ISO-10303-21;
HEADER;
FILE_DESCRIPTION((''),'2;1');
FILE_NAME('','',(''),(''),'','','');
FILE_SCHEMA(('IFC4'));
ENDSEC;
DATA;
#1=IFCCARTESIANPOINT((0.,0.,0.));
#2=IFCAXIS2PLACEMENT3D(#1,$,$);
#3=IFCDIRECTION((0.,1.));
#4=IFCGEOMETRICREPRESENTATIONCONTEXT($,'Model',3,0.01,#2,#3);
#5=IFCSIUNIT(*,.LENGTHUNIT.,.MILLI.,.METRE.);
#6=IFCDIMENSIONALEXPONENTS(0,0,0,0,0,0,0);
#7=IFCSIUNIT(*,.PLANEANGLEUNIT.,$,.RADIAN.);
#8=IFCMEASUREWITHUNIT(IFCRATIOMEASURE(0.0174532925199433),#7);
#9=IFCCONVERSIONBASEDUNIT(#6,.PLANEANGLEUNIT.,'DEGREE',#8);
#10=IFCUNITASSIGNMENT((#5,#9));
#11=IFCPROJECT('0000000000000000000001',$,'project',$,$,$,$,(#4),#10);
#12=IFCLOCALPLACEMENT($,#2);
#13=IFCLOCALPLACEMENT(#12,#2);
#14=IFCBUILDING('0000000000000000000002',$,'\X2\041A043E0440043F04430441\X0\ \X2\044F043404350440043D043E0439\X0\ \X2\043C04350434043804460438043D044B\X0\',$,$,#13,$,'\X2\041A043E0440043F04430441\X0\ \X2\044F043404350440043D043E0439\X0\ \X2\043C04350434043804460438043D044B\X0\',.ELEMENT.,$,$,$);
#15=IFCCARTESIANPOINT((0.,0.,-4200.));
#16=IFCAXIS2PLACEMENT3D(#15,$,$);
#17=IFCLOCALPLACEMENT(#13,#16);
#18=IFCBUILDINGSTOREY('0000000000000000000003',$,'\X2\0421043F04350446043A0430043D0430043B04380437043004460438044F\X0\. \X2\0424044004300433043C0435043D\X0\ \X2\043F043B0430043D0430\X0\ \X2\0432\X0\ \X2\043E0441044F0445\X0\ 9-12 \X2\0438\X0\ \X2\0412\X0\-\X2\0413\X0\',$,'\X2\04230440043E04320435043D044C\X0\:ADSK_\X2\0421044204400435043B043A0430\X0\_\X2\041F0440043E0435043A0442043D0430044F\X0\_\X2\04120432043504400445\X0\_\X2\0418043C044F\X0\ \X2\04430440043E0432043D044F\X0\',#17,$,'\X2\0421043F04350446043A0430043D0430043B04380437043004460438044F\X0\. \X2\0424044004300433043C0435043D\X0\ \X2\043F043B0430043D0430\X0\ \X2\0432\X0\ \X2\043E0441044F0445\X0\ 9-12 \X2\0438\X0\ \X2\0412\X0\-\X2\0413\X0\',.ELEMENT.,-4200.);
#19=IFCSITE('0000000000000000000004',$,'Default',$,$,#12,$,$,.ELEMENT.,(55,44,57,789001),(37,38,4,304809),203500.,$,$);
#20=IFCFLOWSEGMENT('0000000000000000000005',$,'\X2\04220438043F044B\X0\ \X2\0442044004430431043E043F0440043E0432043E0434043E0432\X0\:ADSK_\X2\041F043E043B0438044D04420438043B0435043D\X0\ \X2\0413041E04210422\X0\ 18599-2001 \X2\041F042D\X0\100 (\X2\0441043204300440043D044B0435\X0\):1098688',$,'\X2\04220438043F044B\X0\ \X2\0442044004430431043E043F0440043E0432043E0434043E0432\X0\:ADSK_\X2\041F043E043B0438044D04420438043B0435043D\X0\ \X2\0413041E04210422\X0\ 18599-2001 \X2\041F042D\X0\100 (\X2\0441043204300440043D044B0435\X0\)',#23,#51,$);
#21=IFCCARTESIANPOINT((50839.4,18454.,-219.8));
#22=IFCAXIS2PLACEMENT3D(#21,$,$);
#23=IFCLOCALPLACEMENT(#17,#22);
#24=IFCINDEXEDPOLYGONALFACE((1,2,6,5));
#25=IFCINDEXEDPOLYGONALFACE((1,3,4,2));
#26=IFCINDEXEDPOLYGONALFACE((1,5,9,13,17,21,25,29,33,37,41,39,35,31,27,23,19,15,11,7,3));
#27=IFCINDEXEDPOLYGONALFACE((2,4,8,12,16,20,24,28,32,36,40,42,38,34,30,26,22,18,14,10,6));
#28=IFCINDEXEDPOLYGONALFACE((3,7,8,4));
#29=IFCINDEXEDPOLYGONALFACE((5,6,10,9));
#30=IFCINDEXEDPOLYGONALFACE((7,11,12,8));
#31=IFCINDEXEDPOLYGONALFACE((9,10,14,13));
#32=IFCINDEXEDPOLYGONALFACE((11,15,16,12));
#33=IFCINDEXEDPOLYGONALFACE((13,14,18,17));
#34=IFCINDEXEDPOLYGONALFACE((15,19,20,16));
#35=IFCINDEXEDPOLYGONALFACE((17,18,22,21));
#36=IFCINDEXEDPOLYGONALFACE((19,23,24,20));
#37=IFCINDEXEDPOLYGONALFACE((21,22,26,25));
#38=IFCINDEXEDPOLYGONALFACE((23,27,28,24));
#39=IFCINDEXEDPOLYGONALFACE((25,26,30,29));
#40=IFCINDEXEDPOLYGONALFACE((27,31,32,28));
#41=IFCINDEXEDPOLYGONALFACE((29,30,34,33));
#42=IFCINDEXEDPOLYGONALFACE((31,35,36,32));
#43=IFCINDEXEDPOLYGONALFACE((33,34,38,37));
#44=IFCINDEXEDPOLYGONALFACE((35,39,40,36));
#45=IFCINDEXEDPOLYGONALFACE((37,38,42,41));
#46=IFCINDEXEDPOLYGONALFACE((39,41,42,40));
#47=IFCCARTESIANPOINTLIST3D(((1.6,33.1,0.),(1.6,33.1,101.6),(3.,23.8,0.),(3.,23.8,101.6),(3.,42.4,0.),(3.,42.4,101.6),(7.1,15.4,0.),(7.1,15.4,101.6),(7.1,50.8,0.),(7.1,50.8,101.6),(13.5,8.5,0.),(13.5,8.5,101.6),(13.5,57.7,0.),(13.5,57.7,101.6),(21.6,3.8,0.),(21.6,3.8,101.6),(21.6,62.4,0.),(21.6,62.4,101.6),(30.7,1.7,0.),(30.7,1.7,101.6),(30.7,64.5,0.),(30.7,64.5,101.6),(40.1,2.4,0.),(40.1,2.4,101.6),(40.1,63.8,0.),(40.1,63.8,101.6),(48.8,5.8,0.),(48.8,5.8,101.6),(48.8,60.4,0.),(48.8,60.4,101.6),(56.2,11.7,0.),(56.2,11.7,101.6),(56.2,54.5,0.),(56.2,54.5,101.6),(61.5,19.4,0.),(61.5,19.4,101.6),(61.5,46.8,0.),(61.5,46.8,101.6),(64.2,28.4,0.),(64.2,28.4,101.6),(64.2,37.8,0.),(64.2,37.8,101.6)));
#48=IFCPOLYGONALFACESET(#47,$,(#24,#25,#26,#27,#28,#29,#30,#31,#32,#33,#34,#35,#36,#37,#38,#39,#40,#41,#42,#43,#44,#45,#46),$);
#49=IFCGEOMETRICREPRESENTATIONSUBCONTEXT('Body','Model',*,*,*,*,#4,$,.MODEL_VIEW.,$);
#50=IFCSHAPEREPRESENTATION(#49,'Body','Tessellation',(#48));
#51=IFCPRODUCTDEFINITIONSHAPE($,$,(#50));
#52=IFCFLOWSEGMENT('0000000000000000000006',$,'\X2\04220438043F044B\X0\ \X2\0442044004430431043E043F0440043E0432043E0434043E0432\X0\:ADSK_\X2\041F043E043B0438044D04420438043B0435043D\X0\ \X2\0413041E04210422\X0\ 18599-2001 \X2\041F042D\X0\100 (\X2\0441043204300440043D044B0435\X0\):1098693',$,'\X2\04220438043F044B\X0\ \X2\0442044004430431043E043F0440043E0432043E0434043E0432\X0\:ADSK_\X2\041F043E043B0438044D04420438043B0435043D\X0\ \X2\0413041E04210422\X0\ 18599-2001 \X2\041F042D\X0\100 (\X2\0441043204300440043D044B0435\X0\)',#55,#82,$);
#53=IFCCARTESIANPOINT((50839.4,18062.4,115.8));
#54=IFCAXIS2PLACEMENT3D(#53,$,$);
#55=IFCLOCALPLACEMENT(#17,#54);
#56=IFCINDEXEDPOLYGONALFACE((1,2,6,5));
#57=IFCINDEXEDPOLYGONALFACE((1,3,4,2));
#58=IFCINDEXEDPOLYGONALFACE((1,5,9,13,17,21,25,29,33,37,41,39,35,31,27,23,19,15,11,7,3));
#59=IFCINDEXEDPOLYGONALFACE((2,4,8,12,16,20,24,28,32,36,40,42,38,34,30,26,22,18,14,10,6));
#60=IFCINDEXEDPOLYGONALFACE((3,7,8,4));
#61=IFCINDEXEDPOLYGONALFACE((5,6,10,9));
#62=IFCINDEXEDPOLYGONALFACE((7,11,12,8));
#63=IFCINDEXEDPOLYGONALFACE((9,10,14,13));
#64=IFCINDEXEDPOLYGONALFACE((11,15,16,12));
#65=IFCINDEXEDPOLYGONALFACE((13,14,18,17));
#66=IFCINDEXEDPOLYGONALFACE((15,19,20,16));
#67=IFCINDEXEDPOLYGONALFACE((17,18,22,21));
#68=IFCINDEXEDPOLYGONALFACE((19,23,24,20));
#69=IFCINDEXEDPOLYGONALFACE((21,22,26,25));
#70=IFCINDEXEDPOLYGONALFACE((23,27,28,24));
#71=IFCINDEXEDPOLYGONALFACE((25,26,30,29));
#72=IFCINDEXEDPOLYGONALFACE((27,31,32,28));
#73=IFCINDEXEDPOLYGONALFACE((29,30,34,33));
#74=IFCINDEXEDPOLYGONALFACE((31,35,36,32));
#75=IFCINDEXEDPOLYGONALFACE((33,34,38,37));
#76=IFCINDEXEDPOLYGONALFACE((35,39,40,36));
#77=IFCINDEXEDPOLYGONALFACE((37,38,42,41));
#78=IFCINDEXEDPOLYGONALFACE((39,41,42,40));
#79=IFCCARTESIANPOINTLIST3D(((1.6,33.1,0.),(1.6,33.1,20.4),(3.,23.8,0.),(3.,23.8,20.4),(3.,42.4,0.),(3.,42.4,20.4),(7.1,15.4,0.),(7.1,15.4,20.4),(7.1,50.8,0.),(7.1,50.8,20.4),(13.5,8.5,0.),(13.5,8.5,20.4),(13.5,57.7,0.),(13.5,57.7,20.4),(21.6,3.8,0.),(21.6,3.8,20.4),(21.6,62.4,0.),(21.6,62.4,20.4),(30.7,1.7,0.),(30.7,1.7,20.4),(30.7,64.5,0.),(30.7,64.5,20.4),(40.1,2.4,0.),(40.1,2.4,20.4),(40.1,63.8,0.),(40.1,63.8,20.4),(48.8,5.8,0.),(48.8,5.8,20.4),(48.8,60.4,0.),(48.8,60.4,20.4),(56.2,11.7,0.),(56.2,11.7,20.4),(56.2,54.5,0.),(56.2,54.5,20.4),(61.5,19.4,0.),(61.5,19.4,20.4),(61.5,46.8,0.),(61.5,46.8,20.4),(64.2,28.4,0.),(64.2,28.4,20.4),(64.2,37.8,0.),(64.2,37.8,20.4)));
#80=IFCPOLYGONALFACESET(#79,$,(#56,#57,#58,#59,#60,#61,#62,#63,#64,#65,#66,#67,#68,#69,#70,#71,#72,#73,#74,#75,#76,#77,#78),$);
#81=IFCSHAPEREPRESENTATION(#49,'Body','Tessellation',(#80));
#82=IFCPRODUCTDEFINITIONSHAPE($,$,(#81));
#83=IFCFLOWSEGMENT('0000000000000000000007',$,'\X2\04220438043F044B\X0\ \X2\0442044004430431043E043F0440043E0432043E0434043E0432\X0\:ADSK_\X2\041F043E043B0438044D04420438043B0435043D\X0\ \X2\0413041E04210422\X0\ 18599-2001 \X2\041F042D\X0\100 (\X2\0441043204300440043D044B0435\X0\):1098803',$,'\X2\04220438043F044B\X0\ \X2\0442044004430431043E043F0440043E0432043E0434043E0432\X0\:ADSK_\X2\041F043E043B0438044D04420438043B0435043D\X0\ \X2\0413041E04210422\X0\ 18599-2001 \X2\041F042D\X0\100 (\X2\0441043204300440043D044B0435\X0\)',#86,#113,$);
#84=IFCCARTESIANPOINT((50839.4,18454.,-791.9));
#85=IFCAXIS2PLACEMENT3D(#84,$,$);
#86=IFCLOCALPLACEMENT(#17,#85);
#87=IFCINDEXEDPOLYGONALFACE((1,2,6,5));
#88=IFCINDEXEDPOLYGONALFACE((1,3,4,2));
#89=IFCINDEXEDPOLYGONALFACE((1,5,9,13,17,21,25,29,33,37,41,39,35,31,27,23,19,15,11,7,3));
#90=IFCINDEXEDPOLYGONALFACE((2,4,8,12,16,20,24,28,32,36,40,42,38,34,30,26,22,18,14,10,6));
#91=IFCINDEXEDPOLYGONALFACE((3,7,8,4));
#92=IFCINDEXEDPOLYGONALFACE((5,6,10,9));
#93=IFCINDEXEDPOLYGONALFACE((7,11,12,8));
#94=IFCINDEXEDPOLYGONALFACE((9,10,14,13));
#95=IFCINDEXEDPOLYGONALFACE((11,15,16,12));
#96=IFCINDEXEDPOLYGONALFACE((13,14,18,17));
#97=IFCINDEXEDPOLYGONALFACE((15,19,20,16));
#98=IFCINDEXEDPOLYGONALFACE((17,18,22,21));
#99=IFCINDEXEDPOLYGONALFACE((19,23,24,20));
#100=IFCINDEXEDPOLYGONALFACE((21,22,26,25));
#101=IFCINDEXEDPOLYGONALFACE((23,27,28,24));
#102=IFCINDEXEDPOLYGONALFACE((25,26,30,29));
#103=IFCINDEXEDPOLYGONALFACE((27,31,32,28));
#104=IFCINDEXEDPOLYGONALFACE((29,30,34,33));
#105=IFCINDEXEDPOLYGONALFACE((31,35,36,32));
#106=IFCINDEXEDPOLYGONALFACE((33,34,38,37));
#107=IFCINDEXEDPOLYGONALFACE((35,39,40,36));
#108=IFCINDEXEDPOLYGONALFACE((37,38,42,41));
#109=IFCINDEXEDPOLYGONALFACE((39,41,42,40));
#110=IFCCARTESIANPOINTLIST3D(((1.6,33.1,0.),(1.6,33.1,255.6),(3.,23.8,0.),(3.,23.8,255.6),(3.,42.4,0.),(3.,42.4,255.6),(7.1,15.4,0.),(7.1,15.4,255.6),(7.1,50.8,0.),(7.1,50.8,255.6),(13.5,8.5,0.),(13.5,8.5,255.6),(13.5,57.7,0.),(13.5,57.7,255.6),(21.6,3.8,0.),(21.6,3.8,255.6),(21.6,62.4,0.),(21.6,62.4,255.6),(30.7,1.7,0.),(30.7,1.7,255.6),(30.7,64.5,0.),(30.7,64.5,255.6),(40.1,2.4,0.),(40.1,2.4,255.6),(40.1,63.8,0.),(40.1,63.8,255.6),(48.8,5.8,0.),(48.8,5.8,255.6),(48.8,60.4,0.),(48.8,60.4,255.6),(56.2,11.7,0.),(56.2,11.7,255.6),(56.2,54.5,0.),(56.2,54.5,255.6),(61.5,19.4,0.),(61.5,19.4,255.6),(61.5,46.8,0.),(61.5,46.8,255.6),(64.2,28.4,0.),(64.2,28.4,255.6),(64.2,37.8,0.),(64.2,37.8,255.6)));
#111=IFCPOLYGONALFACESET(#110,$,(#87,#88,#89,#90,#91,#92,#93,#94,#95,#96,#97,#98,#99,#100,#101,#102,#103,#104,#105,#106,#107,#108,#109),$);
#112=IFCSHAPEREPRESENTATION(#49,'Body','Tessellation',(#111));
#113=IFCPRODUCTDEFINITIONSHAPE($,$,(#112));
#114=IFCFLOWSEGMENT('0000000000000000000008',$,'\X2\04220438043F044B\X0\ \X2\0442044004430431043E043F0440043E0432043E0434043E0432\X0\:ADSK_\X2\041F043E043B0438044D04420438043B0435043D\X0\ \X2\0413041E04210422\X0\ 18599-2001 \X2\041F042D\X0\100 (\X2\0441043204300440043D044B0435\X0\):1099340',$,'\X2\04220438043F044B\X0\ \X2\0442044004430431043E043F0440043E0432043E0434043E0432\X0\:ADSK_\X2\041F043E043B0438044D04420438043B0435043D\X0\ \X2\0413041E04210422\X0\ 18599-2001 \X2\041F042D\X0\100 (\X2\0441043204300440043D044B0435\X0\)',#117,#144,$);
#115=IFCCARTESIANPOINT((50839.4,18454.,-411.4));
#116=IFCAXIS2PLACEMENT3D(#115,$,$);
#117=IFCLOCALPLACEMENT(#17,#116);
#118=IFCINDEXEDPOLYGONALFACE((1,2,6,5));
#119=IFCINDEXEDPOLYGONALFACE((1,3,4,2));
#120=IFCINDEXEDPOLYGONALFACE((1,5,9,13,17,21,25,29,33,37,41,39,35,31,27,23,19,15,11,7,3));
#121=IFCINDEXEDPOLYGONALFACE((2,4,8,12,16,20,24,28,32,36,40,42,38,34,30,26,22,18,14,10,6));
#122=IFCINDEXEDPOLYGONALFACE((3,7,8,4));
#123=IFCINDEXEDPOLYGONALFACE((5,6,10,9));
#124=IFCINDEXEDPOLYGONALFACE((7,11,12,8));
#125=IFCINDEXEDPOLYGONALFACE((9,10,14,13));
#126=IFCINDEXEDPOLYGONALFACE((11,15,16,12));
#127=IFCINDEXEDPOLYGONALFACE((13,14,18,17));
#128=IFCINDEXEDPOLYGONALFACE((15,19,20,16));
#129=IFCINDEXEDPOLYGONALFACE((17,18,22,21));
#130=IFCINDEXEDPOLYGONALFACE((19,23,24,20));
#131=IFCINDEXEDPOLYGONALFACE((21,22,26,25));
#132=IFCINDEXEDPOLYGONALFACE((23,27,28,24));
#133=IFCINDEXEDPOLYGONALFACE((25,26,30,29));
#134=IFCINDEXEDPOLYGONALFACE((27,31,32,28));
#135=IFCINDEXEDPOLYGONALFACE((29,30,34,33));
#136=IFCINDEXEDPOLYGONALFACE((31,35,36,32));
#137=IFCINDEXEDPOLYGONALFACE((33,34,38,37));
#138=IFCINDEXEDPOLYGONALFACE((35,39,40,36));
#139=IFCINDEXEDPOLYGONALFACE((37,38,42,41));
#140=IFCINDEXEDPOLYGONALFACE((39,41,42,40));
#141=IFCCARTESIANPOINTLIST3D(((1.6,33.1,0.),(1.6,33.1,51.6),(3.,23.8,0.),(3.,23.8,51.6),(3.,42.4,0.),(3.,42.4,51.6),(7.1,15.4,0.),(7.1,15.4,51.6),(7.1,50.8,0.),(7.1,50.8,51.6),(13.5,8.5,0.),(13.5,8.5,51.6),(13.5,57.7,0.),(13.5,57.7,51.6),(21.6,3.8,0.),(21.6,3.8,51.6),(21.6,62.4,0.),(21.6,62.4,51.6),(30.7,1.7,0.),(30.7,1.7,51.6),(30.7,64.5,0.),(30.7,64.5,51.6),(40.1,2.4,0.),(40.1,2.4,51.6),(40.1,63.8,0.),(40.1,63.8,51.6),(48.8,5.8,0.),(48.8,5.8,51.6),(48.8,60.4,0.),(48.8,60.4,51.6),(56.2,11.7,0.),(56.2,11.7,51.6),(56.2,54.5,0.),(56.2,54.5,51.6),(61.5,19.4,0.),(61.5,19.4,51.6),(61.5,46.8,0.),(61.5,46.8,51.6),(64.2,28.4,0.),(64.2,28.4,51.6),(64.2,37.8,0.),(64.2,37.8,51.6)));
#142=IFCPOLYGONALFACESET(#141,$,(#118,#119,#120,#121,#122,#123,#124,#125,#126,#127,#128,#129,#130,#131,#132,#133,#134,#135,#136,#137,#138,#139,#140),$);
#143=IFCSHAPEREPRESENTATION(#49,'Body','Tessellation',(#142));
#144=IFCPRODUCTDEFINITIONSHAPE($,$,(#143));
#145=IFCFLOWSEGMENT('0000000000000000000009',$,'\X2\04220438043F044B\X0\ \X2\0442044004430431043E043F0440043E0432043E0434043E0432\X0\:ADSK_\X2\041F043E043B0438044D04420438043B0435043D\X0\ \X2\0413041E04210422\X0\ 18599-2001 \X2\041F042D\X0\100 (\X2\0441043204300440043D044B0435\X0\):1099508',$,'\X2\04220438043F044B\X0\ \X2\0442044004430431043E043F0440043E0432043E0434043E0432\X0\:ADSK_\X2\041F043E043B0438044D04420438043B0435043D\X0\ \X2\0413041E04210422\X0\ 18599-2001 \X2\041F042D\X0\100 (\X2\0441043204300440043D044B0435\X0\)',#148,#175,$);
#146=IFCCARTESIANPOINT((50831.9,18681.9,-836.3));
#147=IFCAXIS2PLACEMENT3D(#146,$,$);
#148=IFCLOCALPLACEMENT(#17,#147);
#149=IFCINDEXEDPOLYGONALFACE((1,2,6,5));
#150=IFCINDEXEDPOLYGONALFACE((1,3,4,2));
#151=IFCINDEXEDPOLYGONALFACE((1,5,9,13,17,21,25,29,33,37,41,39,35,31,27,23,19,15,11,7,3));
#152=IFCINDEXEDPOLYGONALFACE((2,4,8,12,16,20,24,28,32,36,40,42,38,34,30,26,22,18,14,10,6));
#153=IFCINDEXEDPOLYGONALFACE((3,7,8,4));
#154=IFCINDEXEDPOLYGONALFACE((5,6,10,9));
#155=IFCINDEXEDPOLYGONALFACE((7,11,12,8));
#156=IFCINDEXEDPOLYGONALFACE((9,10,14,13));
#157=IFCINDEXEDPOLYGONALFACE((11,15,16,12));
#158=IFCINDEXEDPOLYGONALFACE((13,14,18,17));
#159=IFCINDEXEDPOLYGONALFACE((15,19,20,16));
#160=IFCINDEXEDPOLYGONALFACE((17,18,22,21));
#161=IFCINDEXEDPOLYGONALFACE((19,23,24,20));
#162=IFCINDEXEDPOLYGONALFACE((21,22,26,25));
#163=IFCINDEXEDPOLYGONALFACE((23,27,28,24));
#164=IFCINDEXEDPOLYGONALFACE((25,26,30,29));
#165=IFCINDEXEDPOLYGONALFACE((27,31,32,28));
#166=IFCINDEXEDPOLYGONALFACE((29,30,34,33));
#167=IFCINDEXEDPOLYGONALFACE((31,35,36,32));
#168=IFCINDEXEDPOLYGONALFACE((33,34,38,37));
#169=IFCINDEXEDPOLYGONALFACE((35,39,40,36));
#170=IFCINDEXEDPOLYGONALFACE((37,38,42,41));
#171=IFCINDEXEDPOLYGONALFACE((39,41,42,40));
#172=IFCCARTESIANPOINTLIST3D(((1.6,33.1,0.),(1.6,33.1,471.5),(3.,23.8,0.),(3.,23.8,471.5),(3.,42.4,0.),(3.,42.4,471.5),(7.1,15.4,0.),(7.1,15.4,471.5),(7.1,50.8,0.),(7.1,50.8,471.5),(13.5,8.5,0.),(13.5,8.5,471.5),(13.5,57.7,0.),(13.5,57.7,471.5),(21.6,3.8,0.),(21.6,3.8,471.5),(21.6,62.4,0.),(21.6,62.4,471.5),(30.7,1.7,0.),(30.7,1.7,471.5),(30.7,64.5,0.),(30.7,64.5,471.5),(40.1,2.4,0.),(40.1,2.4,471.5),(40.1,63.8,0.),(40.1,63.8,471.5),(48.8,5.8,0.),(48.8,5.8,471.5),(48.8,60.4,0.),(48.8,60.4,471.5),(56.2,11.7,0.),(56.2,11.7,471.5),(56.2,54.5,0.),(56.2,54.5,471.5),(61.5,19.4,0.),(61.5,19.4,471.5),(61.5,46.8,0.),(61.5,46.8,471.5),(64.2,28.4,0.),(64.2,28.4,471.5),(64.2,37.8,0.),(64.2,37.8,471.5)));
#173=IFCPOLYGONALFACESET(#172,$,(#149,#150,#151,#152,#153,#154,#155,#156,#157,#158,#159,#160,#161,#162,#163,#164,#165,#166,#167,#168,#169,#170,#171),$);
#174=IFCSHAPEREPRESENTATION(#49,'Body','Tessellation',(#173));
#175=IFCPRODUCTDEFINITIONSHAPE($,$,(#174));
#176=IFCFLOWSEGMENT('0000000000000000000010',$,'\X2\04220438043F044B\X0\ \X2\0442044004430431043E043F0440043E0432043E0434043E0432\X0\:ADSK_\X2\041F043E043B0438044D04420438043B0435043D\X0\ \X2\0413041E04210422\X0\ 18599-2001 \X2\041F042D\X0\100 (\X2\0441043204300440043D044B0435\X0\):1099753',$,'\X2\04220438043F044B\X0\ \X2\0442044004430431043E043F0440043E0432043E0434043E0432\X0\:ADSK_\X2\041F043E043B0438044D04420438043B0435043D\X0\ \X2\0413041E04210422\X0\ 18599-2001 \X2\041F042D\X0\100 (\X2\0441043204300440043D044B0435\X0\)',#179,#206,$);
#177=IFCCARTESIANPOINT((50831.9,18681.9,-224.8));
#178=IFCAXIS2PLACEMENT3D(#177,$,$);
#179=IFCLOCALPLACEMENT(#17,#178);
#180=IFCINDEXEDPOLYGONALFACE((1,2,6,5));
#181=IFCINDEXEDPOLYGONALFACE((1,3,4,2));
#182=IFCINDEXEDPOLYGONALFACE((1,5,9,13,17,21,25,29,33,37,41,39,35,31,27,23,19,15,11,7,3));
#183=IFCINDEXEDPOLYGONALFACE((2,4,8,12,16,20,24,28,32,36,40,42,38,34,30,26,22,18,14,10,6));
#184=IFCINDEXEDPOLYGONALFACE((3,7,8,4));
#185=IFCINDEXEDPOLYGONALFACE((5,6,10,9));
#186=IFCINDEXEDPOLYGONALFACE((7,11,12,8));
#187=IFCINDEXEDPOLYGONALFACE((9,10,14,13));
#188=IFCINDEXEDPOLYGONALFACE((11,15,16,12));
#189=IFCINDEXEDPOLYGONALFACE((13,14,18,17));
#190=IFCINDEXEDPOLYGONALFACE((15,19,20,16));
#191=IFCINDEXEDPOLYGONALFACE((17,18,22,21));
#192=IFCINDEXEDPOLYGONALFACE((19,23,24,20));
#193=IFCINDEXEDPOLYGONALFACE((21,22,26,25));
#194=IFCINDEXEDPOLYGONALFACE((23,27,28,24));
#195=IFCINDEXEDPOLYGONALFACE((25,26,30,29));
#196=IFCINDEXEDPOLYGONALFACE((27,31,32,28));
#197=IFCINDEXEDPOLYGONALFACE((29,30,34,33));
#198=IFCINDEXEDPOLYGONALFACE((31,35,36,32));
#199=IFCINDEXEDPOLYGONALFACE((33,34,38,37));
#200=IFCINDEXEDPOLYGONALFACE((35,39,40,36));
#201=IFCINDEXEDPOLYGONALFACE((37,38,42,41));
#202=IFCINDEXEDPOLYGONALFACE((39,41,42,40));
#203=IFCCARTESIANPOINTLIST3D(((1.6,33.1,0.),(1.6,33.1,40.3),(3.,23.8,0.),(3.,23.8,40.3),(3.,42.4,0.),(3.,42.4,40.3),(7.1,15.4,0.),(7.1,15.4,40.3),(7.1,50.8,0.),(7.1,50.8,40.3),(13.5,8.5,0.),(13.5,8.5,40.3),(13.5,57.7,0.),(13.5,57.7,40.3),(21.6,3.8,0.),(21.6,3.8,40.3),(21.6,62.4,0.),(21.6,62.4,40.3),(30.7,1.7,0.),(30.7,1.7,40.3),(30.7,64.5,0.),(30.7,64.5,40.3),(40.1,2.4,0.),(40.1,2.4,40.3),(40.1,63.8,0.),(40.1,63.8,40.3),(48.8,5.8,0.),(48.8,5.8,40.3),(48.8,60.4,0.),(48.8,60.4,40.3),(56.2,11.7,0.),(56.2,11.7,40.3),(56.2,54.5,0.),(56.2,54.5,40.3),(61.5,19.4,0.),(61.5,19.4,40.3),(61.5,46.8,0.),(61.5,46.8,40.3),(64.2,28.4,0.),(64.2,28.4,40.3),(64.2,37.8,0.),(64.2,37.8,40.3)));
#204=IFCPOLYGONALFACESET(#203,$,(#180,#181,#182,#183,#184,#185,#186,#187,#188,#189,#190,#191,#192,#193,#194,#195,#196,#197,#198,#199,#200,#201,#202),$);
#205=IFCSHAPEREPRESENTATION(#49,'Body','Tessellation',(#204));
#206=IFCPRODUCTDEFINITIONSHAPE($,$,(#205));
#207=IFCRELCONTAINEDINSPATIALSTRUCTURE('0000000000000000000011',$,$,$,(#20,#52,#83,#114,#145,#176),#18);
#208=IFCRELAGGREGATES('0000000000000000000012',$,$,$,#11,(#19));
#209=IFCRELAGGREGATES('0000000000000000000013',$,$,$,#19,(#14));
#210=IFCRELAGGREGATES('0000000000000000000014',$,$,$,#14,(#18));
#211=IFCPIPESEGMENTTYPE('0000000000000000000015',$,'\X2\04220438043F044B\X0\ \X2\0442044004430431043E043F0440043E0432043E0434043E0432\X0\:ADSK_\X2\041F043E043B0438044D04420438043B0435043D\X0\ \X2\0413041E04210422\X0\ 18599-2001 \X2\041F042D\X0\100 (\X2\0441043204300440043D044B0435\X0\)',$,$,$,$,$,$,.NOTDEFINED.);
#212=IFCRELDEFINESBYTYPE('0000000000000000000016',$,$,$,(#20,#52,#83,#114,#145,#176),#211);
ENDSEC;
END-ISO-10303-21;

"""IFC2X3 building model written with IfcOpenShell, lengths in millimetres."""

from ifc_helpers import new_model, entity, si_unit, converted_unit, direction, frame, frame_2d, origin, origin_2d_with_axis, place, context, subcontext, project, spatial, circle, extrude, type_object, element, save


model = new_model("IFC2X3")

# Units and contexts
model_context = context("Model", 3, precision=0.01, world=origin(), true_north=direction((0.0, 1.0)))
body_context = subcontext(model_context, "Body", "Model", "MODEL_VIEW")
ifc_project = project(units=[si_unit("LENGTHUNIT", "METRE", prefix="MILLI"), converted_unit("PLANEANGLEUNIT", "DEGREE", entity("IfcRatioMeasure", 0.0174532925199433), si_unit("PLANEANGLEUNIT", "RADIAN"), dimensions=[0, 0, 0, 0, 0, 0, 0])], contexts=[model_context])

# Site, building, storey
site_placement = place(None, frame((0.0, 0.0, 0.0)))
site = spatial("IfcSite", under=ifc_project, at=site_placement, Name="Default", CompositionType="ELEMENT", RefLatitude=(55, 44, 57, 789001), RefLongitude=(37, 38, 4, 304809), RefElevation=203500.0)
building_placement = place(site_placement, origin())
building = spatial("IfcBuilding", under=site, at=building_placement, Name="Корпус ядерной медицины", LongName="Корпус ядерной медицины", CompositionType="ELEMENT")
storey_placement = place(building_placement, frame((0.0, 0.0, -4200.0)))
storey = spatial("IfcBuildingStorey", under=building, at=storey_placement, Name="Спецканализация. Фрагмен плана в осях 9-12 и В-Г", ObjectType="Уровень:ADSK_Стрелка_Проектная_Вверх_Имя уровня", LongName="Спецканализация. Фрагмен плана в осях 9-12 и В-Г", CompositionType="ELEMENT", Elevation=-4200.0)

# Flow segments
pipe_segment_type = type_object("IfcPipeSegmentType", Name="Типы трубопроводов:ADSK_Полиэтилен ГОСТ 18599-2001 ПЭ100 (сварные)", PredefinedType="NOTDEFINED")
flow_segment_1_placement = place(storey_placement, frame((50839.4, 18454.0, -219.8)))
element("IfcFlowSegment", 1, at=flow_segment_1_placement, inside=storey, type_object=pipe_segment_type, Name="Типы трубопроводов:ADSK_Полиэтилен ГОСТ 18599-2001 ПЭ100 (сварные):1098688", ObjectType="Типы трубопроводов:ADSK_Полиэтилен ГОСТ 18599-2001 ПЭ100 (сварные)", context=body_context, shape_type="SweptSolid", body=[
    extrude(circle(Radius=31.5, at=frame_2d((0.0, 0.0), x_axis=(1.0, 0.0))), frame((33.1, 33.1, 0.0), z_axis=(0.0, 0.0, 1.0), x_axis=(-1.0, 0.0, 0.0)), (0.0, 0.0, 1.0), 101.6),
])
flow_segment_2_placement = place(storey_placement, frame((50839.4, 18062.4, 115.8)))
element("IfcFlowSegment", 2, at=flow_segment_2_placement, inside=storey, type_object=pipe_segment_type, Name="Типы трубопроводов:ADSK_Полиэтилен ГОСТ 18599-2001 ПЭ100 (сварные):1098693", ObjectType="Типы трубопроводов:ADSK_Полиэтилен ГОСТ 18599-2001 ПЭ100 (сварные)", context=body_context, shape_type="SweptSolid", body=[
    extrude(circle(Radius=31.5, at=frame_2d((0.0, 0.0), x_axis=(1.0, 0.0))), frame((33.1, 33.1, 0.0), z_axis=(0.0, 0.0, 1.0), x_axis=(-1.0, 0.0, 0.0)), (0.0, 0.0, 1.0), 20.4),
])
flow_segment_3_placement = place(storey_placement, frame((50839.4, 18454.0, -791.9)))
element("IfcFlowSegment", 3, at=flow_segment_3_placement, inside=storey, type_object=pipe_segment_type, Name="Типы трубопроводов:ADSK_Полиэтилен ГОСТ 18599-2001 ПЭ100 (сварные):1098803", ObjectType="Типы трубопроводов:ADSK_Полиэтилен ГОСТ 18599-2001 ПЭ100 (сварные)", context=body_context, shape_type="SweptSolid", body=[
    extrude(circle(Radius=31.5, at=origin_2d_with_axis()), frame((33.1, 33.1, 0.0), z_axis=(0.0, 0.0, 1.0), x_axis=(-1.0, 0.0, 0.0)), (0.0, 0.0, 1.0), 255.6),
])
flow_segment_4_placement = place(storey_placement, frame((50839.4, 18454.0, -411.4)))
element("IfcFlowSegment", 4, at=flow_segment_4_placement, inside=storey, type_object=pipe_segment_type, Name="Типы трубопроводов:ADSK_Полиэтилен ГОСТ 18599-2001 ПЭ100 (сварные):1099340", ObjectType="Типы трубопроводов:ADSK_Полиэтилен ГОСТ 18599-2001 ПЭ100 (сварные)", context=body_context, shape_type="SweptSolid", body=[
    extrude(circle(Radius=31.5, at=frame_2d((0.0, 0.0), x_axis=(1.0, 0.0))), frame((33.1, 33.1, 0.0), z_axis=(0.0, 0.0, 1.0), x_axis=(-1.0, 0.0, 0.0)), (0.0, 0.0, 1.0), 51.6),
])
flow_segment_5_placement = place(storey_placement, frame((50831.9, 18681.9, -836.3)))
element("IfcFlowSegment", 5, at=flow_segment_5_placement, inside=storey, type_object=pipe_segment_type, Name="Типы трубопроводов:ADSK_Полиэтилен ГОСТ 18599-2001 ПЭ100 (сварные):1099508", ObjectType="Типы трубопроводов:ADSK_Полиэтилен ГОСТ 18599-2001 ПЭ100 (сварные)", context=body_context, shape_type="SweptSolid", body=[
    extrude(circle(Radius=31.5, at=frame_2d((0.0, 0.0), x_axis=(1.0, 0.0))), frame((33.1, 33.1, 0.0), z_axis=(0.0, 0.0, 1.0), x_axis=(-1.0, 0.0, 0.0)), (0.0, 0.0, 1.0), 471.5),
])
flow_segment_6_placement = place(storey_placement, frame((50831.9, 18681.9, -224.8)))
element("IfcFlowSegment", 6, at=flow_segment_6_placement, inside=storey, type_object=pipe_segment_type, Name="Типы трубопроводов:ADSK_Полиэтилен ГОСТ 18599-2001 ПЭ100 (сварные):1099753", ObjectType="Типы трубопроводов:ADSK_Полиэтилен ГОСТ 18599-2001 ПЭ100 (сварные)", context=body_context, shape_type="SweptSolid", body=[
    extrude(circle(Radius=31.5, at=origin_2d_with_axis()), frame((33.1, 33.1, 0.0), z_axis=(0.0, 0.0, 1.0), x_axis=(-1.0, 0.0, 0.0)), (0.0, 0.0, 1.0), 40.3),
])

save(model, "model.ifc")
